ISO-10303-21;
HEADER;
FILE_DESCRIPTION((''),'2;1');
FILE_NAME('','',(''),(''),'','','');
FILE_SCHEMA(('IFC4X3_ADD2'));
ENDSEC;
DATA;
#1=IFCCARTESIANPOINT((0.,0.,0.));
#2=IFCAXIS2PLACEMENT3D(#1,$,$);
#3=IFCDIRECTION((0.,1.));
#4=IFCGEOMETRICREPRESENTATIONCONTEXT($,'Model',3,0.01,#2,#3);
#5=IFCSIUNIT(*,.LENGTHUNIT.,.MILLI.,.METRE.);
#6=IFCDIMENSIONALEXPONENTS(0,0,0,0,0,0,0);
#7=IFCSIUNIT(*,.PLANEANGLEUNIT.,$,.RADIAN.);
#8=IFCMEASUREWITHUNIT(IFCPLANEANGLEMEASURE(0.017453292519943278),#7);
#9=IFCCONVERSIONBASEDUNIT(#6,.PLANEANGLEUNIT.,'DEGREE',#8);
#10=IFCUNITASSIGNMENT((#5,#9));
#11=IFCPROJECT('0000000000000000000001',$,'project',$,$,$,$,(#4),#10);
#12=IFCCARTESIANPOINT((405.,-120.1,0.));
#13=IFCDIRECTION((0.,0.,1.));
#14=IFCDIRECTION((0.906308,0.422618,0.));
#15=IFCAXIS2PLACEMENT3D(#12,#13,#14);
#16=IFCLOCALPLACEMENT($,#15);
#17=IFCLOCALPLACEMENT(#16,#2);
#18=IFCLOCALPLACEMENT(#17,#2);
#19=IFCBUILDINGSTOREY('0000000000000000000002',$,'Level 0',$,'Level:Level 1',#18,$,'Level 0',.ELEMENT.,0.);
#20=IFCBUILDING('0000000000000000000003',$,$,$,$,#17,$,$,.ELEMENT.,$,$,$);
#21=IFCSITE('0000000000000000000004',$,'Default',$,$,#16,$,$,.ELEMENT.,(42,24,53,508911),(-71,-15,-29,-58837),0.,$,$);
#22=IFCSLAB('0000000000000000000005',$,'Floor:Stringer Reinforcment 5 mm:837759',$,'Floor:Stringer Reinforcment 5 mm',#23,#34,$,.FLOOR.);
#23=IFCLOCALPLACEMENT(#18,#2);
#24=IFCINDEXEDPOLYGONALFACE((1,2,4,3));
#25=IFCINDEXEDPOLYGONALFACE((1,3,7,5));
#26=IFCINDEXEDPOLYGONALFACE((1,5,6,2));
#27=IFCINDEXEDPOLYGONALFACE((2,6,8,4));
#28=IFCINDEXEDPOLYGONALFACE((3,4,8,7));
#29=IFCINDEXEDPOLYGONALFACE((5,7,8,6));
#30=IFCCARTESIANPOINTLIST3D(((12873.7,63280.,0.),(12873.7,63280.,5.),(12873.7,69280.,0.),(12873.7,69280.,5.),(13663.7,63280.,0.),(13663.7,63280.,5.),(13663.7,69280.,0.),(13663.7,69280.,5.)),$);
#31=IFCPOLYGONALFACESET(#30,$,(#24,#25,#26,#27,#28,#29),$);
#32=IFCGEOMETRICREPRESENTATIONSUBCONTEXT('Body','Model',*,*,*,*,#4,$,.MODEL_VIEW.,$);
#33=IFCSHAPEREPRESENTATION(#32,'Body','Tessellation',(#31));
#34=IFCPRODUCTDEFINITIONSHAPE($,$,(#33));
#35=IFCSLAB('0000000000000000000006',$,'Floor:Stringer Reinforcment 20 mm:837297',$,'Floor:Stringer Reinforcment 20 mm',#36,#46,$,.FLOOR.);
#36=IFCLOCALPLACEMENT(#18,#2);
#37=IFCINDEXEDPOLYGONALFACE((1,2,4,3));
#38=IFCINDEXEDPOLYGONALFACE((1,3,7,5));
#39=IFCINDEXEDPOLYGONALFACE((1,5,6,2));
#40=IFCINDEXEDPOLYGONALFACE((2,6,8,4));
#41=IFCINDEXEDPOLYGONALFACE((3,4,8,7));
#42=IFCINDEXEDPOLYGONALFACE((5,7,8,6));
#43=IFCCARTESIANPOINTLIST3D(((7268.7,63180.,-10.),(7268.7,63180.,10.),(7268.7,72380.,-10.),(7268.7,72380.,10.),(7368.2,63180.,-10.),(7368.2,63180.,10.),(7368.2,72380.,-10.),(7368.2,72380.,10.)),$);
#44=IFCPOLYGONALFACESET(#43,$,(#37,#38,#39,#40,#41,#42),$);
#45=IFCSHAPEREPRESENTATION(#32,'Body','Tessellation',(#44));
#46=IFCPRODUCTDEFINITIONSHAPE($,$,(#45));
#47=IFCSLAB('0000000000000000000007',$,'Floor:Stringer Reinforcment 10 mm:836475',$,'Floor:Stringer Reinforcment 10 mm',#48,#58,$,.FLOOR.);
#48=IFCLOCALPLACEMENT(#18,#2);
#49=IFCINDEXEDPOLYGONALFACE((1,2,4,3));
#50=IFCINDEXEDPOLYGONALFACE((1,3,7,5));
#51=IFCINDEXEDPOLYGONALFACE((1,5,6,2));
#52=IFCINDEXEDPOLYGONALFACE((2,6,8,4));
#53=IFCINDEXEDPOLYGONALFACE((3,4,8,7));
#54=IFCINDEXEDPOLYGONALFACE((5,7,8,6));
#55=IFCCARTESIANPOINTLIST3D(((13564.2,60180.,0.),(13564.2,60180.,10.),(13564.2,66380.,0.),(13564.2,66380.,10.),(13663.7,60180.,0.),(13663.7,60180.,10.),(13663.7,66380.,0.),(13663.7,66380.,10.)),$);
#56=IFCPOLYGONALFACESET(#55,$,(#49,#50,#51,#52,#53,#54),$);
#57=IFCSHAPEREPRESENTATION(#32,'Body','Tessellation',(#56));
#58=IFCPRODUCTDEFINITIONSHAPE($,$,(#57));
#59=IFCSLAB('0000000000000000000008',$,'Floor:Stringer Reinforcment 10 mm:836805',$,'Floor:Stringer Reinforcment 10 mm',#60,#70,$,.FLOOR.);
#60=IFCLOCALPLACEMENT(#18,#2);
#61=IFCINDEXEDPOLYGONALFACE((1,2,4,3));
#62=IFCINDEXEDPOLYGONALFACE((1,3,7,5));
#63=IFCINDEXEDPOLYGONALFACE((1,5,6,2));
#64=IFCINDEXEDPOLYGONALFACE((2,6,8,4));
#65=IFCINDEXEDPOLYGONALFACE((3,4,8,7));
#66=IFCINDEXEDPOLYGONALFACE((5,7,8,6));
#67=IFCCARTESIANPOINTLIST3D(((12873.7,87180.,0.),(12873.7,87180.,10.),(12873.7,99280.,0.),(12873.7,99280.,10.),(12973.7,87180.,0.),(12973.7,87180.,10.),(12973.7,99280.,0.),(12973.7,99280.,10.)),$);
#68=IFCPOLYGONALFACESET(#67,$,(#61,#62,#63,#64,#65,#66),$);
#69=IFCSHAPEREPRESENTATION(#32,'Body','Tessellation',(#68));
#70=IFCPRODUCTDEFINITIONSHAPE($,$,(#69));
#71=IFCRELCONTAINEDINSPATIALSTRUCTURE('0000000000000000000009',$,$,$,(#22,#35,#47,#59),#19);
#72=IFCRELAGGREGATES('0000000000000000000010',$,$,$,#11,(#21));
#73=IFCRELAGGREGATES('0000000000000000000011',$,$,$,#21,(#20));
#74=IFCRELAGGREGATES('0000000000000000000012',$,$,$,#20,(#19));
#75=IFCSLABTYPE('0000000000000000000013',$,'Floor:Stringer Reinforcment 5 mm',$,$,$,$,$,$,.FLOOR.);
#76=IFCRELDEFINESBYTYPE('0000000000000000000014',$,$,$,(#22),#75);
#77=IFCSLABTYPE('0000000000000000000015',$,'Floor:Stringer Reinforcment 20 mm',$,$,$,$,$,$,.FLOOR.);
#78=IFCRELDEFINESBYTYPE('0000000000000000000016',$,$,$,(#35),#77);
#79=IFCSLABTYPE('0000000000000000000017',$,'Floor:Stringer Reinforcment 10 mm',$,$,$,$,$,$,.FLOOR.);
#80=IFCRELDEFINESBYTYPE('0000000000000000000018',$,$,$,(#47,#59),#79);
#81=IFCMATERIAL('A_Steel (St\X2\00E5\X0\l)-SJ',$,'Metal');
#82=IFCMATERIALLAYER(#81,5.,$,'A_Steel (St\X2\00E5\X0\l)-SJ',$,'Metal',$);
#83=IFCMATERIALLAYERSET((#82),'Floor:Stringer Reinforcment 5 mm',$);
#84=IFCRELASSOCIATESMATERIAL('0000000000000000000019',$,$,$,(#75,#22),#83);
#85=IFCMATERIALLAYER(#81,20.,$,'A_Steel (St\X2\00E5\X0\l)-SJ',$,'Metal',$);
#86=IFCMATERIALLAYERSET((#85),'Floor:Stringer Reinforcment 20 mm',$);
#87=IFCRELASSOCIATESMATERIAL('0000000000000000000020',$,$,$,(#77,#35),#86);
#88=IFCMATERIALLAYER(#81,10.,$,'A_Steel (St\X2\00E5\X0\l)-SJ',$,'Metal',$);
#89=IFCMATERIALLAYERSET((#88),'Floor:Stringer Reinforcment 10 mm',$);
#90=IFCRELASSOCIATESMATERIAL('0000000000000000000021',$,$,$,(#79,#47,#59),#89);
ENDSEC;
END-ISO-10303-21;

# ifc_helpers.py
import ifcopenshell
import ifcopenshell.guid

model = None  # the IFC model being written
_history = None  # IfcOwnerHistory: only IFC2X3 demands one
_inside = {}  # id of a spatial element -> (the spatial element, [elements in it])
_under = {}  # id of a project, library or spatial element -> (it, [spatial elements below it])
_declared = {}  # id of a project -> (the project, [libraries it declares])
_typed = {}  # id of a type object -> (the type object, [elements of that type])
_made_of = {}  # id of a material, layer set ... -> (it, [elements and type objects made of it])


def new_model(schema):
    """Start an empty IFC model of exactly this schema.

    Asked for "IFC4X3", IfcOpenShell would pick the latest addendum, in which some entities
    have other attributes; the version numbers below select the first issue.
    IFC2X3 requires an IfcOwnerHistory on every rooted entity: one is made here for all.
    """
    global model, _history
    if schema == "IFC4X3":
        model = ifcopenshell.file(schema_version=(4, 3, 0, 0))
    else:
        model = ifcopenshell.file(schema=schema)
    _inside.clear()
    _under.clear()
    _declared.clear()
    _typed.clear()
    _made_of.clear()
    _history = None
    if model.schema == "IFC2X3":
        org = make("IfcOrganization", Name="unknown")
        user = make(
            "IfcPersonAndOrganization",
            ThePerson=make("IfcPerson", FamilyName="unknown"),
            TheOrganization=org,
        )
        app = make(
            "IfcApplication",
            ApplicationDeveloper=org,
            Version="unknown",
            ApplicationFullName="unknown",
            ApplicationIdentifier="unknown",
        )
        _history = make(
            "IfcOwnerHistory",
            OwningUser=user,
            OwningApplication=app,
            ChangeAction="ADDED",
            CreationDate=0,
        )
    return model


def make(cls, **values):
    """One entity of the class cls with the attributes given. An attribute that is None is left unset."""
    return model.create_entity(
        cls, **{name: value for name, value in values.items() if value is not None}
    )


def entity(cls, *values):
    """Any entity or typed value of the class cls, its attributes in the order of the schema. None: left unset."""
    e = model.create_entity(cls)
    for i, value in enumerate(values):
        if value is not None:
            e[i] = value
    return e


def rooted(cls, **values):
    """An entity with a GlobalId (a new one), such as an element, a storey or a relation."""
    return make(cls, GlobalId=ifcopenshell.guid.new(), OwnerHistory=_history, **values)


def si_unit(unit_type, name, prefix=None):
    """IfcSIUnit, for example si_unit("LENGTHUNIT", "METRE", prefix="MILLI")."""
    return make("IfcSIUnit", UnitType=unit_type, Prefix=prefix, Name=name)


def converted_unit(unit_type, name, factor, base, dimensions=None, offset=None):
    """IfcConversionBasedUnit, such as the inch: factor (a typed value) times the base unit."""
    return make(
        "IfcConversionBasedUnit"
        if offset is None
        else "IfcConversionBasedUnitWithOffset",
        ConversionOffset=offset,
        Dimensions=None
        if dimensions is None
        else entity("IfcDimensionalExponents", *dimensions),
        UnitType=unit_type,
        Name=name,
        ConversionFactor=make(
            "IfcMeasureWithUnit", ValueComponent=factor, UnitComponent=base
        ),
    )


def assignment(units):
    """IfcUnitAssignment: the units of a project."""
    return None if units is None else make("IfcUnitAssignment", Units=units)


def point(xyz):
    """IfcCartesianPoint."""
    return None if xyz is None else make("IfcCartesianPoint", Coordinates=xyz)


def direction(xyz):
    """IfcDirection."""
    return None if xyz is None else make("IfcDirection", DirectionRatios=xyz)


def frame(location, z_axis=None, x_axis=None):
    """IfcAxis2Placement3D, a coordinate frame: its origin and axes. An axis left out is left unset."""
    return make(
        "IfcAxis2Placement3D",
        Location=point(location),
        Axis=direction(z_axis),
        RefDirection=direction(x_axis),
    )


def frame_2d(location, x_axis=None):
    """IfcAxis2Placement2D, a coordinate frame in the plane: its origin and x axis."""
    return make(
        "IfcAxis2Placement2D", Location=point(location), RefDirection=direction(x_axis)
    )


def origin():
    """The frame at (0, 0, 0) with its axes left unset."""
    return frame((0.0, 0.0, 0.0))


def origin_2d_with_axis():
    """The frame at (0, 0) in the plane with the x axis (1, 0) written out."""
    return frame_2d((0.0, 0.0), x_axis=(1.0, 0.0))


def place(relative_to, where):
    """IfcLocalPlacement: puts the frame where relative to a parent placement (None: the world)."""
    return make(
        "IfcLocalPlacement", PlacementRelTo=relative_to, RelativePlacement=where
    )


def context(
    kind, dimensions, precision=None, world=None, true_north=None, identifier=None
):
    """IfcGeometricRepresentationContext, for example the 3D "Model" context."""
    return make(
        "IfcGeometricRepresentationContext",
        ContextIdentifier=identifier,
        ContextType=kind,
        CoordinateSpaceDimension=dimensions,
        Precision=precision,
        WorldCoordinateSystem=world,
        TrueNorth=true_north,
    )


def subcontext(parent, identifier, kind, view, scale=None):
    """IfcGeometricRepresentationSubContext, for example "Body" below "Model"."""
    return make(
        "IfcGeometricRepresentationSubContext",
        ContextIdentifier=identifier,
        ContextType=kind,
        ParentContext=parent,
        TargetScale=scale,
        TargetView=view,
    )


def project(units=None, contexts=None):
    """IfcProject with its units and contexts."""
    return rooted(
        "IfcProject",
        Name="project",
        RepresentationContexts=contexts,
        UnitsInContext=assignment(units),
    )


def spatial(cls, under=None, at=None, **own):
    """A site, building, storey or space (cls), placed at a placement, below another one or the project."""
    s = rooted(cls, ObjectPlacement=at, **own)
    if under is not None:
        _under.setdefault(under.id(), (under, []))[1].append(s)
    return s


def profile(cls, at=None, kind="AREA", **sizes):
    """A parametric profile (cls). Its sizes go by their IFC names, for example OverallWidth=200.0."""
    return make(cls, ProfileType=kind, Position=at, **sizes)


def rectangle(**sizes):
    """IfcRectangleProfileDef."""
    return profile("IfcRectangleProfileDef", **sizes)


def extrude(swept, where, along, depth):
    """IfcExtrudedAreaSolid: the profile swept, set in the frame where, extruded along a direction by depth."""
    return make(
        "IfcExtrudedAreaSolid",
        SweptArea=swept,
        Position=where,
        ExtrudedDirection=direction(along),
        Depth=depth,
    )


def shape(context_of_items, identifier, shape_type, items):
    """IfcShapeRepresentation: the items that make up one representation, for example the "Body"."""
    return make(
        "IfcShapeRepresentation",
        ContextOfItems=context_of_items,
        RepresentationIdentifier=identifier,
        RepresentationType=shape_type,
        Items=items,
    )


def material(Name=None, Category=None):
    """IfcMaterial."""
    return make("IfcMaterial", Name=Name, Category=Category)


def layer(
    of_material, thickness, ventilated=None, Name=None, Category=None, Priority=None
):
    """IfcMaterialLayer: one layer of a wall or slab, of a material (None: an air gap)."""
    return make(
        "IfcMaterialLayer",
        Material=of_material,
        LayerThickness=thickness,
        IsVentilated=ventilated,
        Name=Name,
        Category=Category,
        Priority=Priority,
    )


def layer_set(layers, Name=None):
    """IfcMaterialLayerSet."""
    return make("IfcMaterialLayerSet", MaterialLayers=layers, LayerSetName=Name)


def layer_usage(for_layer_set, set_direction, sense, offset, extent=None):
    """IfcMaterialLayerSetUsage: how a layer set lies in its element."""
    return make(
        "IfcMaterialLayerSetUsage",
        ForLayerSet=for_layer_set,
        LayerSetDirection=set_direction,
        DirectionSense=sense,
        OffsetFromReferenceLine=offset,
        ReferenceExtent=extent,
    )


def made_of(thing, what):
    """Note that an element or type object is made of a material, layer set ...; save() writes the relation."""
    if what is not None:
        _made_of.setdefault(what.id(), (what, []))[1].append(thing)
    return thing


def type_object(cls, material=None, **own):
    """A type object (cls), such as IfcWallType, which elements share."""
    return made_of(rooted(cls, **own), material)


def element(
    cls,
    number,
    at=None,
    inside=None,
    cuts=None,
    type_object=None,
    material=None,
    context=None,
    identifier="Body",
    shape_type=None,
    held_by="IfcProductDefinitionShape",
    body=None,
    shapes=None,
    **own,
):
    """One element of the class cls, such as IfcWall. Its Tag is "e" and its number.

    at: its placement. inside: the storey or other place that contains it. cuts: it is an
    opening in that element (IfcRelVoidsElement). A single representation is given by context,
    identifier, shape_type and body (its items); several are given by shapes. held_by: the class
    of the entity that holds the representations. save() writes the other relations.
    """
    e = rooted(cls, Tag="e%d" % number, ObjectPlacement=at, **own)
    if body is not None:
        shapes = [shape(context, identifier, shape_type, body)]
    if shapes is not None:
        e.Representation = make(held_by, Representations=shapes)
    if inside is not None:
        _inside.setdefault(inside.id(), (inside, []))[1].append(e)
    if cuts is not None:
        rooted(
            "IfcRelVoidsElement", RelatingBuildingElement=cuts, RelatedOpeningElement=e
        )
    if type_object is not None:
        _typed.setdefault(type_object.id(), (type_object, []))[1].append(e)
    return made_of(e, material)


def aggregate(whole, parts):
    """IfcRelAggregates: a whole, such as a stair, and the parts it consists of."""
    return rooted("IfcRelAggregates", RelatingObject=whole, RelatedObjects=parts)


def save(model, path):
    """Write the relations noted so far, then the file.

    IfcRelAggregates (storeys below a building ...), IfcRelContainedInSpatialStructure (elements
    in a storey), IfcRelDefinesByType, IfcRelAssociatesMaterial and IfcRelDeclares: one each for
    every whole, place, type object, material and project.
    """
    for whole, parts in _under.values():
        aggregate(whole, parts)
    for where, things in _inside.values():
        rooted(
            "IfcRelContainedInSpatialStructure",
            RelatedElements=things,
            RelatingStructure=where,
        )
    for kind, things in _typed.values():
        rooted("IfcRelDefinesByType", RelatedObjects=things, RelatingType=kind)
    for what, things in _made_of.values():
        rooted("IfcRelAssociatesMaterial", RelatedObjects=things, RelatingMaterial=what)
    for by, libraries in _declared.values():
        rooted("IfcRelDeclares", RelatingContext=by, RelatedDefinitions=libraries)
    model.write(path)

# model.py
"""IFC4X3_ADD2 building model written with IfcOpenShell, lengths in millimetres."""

from ifc_helpers import new_model, entity, si_unit, converted_unit, direction, frame, frame_2d, origin, origin_2d_with_axis, place, context, subcontext, project, spatial, rectangle, extrude, material, layer, layer_set, layer_usage, type_object, element, save


model = new_model("IFC4X3_ADD2")

# Units and contexts
model_context = context("Model", 3, precision=0.01, world=origin(), true_north=direction((0.0, 1.0)))
body_context = subcontext(model_context, "Body", "Model", "MODEL_VIEW")
ifc_project = project(units=[si_unit("LENGTHUNIT", "METRE", prefix="MILLI"), converted_unit("PLANEANGLEUNIT", "DEGREE", entity("IfcPlaneAngleMeasure", 0.017453292519943278), si_unit("PLANEANGLEUNIT", "RADIAN"), dimensions=[0, 0, 0, 0, 0, 0, 0])], contexts=[model_context])

# Site, building, storey
site_placement = place(None, frame((405.0, -120.1, 0.0), z_axis=(0.0, 0.0, 1.0), x_axis=(0.906308, 0.422618, 0.0)))
site = spatial("IfcSite", under=ifc_project, at=site_placement, Name="Default", CompositionType="ELEMENT", RefLatitude=(42, 24, 53, 508911), RefLongitude=(-71, -15, -29, -58837), RefElevation=0.0)
building_placement = place(site_placement, origin())
building = spatial("IfcBuilding", under=site, at=building_placement, CompositionType="ELEMENT")
storey_placement = place(building_placement, origin())
storey = spatial("IfcBuildingStorey", under=building, at=storey_placement, Name="Level 0", ObjectType="Level:Level 1", LongName="Level 0", CompositionType="ELEMENT", Elevation=0.0)

# Slabs
ifc_material_1 = material(Name="A_Steel (Stål)-SJ", Category="Metal")
ifc_layer_1 = layer(ifc_material_1, 5.0, Name="A_Steel (Stål)-SJ", Category="Metal")
ifc_layer_set_1 = layer_set([ifc_layer_1], Name="Floor:Stringer Reinforcment 5 mm")
slab_type_1 = type_object("IfcSlabType", Name="Floor:Stringer Reinforcment 5 mm", PredefinedType="FLOOR", material=ifc_layer_set_1)
ifc_layer_usage_1 = layer_usage(ifc_layer_set_1, "AXIS3", "POSITIVE", 0.0)
slab_1_placement = place(storey_placement, origin())
element("IfcSlab", 1, at=slab_1_placement, inside=storey, type_object=slab_type_1, material=ifc_layer_usage_1, Name="Floor:Stringer Reinforcment 5 mm:837759", ObjectType="Floor:Stringer Reinforcment 5 mm", PredefinedType="FLOOR", context=body_context, shape_type="SweptSolid", body=[
    extrude(rectangle(XDim=6000.0, YDim=790.0, at=frame_2d((0.0, 0.0), x_axis=(1.0, 0.0))), frame((13268.7, 66280.0, 5.0), z_axis=(0.0, 0.0, -1.0), x_axis=(0.0, 1.0, 0.0)), (0.0, 0.0, 1.0), 5.0),
])
ifc_layer_2 = layer(ifc_material_1, 20.0, Name="A_Steel (Stål)-SJ", Category="Metal")
ifc_layer_set_2 = layer_set([ifc_layer_2], Name="Floor:Stringer Reinforcment 20 mm")
ifc_layer_usage_2 = layer_usage(ifc_layer_set_2, "AXIS3", "POSITIVE", 0.0)
slab_type_2 = type_object("IfcSlabType", Name="Floor:Stringer Reinforcment 20 mm", PredefinedType="FLOOR", material=ifc_layer_set_2)
slab_2_placement = place(storey_placement, origin())
element("IfcSlab", 2, at=slab_2_placement, inside=storey, type_object=slab_type_2, material=ifc_layer_usage_2, Name="Floor:Stringer Reinforcment 20 mm:837297", ObjectType="Floor:Stringer Reinforcment 20 mm", PredefinedType="FLOOR", context=body_context, shape_type="SweptSolid", body=[
    extrude(rectangle(XDim=9200.0, YDim=99.5, at=frame_2d((0.0, 0.0), x_axis=(1.0, 0.0))), frame((7318.5, 67780.0, 10.0), z_axis=(0.0, 0.0, -1.0), x_axis=(0.0, 1.0, 0.0)), (0.0, 0.0, 1.0), 20.0),
])
ifc_layer_3 = layer(ifc_material_1, 10.0, Name="A_Steel (Stål)-SJ", Category="Metal")
ifc_layer_set_3 = layer_set([ifc_layer_3], Name="Floor:Stringer Reinforcment 10 mm")
ifc_layer_usage_3 = layer_usage(ifc_layer_set_3, "AXIS3", "POSITIVE", 0.0)
slab_type_3 = type_object("IfcSlabType", Name="Floor:Stringer Reinforcment 10 mm", PredefinedType="FLOOR", material=ifc_layer_set_3)
slab_3_placement = place(storey_placement, origin())
element("IfcSlab", 3, at=slab_3_placement, inside=storey, type_object=slab_type_3, material=ifc_layer_usage_3, Name="Floor:Stringer Reinforcment 10 mm:836475", ObjectType="Floor:Stringer Reinforcment 10 mm", PredefinedType="FLOOR", context=body_context, shape_type="SweptSolid", body=[
    extrude(rectangle(XDim=6200.0, YDim=99.5, at=origin_2d_with_axis()), frame((13614.0, 63280.0, 10.0), z_axis=(0.0, 0.0, -1.0), x_axis=(0.0, 1.0, 0.0)), (0.0, 0.0, 1.0), 10.0),
])
ifc_layer_usage_4 = layer_usage(ifc_layer_set_3, "AXIS3", "POSITIVE", 0.0)
slab_4_placement = place(storey_placement, origin())
element("IfcSlab", 4, at=slab_4_placement, inside=storey, type_object=slab_type_3, material=ifc_layer_usage_4, Name="Floor:Stringer Reinforcment 10 mm:836805", ObjectType="Floor:Stringer Reinforcment 10 mm", PredefinedType="FLOOR", context=body_context, shape_type="SweptSolid", body=[
    extrude(rectangle(XDim=12100.0, YDim=100.0, at=frame_2d((0.0, 0.0), x_axis=(1.0, 0.0))), frame((12923.7, 93230.0, 10.0), z_axis=(0.0, 0.0, -1.0), x_axis=(0.0, 1.0, 0.0)), (0.0, 0.0, 1.0), 10.0),
])

save(model, "model.ifc")
